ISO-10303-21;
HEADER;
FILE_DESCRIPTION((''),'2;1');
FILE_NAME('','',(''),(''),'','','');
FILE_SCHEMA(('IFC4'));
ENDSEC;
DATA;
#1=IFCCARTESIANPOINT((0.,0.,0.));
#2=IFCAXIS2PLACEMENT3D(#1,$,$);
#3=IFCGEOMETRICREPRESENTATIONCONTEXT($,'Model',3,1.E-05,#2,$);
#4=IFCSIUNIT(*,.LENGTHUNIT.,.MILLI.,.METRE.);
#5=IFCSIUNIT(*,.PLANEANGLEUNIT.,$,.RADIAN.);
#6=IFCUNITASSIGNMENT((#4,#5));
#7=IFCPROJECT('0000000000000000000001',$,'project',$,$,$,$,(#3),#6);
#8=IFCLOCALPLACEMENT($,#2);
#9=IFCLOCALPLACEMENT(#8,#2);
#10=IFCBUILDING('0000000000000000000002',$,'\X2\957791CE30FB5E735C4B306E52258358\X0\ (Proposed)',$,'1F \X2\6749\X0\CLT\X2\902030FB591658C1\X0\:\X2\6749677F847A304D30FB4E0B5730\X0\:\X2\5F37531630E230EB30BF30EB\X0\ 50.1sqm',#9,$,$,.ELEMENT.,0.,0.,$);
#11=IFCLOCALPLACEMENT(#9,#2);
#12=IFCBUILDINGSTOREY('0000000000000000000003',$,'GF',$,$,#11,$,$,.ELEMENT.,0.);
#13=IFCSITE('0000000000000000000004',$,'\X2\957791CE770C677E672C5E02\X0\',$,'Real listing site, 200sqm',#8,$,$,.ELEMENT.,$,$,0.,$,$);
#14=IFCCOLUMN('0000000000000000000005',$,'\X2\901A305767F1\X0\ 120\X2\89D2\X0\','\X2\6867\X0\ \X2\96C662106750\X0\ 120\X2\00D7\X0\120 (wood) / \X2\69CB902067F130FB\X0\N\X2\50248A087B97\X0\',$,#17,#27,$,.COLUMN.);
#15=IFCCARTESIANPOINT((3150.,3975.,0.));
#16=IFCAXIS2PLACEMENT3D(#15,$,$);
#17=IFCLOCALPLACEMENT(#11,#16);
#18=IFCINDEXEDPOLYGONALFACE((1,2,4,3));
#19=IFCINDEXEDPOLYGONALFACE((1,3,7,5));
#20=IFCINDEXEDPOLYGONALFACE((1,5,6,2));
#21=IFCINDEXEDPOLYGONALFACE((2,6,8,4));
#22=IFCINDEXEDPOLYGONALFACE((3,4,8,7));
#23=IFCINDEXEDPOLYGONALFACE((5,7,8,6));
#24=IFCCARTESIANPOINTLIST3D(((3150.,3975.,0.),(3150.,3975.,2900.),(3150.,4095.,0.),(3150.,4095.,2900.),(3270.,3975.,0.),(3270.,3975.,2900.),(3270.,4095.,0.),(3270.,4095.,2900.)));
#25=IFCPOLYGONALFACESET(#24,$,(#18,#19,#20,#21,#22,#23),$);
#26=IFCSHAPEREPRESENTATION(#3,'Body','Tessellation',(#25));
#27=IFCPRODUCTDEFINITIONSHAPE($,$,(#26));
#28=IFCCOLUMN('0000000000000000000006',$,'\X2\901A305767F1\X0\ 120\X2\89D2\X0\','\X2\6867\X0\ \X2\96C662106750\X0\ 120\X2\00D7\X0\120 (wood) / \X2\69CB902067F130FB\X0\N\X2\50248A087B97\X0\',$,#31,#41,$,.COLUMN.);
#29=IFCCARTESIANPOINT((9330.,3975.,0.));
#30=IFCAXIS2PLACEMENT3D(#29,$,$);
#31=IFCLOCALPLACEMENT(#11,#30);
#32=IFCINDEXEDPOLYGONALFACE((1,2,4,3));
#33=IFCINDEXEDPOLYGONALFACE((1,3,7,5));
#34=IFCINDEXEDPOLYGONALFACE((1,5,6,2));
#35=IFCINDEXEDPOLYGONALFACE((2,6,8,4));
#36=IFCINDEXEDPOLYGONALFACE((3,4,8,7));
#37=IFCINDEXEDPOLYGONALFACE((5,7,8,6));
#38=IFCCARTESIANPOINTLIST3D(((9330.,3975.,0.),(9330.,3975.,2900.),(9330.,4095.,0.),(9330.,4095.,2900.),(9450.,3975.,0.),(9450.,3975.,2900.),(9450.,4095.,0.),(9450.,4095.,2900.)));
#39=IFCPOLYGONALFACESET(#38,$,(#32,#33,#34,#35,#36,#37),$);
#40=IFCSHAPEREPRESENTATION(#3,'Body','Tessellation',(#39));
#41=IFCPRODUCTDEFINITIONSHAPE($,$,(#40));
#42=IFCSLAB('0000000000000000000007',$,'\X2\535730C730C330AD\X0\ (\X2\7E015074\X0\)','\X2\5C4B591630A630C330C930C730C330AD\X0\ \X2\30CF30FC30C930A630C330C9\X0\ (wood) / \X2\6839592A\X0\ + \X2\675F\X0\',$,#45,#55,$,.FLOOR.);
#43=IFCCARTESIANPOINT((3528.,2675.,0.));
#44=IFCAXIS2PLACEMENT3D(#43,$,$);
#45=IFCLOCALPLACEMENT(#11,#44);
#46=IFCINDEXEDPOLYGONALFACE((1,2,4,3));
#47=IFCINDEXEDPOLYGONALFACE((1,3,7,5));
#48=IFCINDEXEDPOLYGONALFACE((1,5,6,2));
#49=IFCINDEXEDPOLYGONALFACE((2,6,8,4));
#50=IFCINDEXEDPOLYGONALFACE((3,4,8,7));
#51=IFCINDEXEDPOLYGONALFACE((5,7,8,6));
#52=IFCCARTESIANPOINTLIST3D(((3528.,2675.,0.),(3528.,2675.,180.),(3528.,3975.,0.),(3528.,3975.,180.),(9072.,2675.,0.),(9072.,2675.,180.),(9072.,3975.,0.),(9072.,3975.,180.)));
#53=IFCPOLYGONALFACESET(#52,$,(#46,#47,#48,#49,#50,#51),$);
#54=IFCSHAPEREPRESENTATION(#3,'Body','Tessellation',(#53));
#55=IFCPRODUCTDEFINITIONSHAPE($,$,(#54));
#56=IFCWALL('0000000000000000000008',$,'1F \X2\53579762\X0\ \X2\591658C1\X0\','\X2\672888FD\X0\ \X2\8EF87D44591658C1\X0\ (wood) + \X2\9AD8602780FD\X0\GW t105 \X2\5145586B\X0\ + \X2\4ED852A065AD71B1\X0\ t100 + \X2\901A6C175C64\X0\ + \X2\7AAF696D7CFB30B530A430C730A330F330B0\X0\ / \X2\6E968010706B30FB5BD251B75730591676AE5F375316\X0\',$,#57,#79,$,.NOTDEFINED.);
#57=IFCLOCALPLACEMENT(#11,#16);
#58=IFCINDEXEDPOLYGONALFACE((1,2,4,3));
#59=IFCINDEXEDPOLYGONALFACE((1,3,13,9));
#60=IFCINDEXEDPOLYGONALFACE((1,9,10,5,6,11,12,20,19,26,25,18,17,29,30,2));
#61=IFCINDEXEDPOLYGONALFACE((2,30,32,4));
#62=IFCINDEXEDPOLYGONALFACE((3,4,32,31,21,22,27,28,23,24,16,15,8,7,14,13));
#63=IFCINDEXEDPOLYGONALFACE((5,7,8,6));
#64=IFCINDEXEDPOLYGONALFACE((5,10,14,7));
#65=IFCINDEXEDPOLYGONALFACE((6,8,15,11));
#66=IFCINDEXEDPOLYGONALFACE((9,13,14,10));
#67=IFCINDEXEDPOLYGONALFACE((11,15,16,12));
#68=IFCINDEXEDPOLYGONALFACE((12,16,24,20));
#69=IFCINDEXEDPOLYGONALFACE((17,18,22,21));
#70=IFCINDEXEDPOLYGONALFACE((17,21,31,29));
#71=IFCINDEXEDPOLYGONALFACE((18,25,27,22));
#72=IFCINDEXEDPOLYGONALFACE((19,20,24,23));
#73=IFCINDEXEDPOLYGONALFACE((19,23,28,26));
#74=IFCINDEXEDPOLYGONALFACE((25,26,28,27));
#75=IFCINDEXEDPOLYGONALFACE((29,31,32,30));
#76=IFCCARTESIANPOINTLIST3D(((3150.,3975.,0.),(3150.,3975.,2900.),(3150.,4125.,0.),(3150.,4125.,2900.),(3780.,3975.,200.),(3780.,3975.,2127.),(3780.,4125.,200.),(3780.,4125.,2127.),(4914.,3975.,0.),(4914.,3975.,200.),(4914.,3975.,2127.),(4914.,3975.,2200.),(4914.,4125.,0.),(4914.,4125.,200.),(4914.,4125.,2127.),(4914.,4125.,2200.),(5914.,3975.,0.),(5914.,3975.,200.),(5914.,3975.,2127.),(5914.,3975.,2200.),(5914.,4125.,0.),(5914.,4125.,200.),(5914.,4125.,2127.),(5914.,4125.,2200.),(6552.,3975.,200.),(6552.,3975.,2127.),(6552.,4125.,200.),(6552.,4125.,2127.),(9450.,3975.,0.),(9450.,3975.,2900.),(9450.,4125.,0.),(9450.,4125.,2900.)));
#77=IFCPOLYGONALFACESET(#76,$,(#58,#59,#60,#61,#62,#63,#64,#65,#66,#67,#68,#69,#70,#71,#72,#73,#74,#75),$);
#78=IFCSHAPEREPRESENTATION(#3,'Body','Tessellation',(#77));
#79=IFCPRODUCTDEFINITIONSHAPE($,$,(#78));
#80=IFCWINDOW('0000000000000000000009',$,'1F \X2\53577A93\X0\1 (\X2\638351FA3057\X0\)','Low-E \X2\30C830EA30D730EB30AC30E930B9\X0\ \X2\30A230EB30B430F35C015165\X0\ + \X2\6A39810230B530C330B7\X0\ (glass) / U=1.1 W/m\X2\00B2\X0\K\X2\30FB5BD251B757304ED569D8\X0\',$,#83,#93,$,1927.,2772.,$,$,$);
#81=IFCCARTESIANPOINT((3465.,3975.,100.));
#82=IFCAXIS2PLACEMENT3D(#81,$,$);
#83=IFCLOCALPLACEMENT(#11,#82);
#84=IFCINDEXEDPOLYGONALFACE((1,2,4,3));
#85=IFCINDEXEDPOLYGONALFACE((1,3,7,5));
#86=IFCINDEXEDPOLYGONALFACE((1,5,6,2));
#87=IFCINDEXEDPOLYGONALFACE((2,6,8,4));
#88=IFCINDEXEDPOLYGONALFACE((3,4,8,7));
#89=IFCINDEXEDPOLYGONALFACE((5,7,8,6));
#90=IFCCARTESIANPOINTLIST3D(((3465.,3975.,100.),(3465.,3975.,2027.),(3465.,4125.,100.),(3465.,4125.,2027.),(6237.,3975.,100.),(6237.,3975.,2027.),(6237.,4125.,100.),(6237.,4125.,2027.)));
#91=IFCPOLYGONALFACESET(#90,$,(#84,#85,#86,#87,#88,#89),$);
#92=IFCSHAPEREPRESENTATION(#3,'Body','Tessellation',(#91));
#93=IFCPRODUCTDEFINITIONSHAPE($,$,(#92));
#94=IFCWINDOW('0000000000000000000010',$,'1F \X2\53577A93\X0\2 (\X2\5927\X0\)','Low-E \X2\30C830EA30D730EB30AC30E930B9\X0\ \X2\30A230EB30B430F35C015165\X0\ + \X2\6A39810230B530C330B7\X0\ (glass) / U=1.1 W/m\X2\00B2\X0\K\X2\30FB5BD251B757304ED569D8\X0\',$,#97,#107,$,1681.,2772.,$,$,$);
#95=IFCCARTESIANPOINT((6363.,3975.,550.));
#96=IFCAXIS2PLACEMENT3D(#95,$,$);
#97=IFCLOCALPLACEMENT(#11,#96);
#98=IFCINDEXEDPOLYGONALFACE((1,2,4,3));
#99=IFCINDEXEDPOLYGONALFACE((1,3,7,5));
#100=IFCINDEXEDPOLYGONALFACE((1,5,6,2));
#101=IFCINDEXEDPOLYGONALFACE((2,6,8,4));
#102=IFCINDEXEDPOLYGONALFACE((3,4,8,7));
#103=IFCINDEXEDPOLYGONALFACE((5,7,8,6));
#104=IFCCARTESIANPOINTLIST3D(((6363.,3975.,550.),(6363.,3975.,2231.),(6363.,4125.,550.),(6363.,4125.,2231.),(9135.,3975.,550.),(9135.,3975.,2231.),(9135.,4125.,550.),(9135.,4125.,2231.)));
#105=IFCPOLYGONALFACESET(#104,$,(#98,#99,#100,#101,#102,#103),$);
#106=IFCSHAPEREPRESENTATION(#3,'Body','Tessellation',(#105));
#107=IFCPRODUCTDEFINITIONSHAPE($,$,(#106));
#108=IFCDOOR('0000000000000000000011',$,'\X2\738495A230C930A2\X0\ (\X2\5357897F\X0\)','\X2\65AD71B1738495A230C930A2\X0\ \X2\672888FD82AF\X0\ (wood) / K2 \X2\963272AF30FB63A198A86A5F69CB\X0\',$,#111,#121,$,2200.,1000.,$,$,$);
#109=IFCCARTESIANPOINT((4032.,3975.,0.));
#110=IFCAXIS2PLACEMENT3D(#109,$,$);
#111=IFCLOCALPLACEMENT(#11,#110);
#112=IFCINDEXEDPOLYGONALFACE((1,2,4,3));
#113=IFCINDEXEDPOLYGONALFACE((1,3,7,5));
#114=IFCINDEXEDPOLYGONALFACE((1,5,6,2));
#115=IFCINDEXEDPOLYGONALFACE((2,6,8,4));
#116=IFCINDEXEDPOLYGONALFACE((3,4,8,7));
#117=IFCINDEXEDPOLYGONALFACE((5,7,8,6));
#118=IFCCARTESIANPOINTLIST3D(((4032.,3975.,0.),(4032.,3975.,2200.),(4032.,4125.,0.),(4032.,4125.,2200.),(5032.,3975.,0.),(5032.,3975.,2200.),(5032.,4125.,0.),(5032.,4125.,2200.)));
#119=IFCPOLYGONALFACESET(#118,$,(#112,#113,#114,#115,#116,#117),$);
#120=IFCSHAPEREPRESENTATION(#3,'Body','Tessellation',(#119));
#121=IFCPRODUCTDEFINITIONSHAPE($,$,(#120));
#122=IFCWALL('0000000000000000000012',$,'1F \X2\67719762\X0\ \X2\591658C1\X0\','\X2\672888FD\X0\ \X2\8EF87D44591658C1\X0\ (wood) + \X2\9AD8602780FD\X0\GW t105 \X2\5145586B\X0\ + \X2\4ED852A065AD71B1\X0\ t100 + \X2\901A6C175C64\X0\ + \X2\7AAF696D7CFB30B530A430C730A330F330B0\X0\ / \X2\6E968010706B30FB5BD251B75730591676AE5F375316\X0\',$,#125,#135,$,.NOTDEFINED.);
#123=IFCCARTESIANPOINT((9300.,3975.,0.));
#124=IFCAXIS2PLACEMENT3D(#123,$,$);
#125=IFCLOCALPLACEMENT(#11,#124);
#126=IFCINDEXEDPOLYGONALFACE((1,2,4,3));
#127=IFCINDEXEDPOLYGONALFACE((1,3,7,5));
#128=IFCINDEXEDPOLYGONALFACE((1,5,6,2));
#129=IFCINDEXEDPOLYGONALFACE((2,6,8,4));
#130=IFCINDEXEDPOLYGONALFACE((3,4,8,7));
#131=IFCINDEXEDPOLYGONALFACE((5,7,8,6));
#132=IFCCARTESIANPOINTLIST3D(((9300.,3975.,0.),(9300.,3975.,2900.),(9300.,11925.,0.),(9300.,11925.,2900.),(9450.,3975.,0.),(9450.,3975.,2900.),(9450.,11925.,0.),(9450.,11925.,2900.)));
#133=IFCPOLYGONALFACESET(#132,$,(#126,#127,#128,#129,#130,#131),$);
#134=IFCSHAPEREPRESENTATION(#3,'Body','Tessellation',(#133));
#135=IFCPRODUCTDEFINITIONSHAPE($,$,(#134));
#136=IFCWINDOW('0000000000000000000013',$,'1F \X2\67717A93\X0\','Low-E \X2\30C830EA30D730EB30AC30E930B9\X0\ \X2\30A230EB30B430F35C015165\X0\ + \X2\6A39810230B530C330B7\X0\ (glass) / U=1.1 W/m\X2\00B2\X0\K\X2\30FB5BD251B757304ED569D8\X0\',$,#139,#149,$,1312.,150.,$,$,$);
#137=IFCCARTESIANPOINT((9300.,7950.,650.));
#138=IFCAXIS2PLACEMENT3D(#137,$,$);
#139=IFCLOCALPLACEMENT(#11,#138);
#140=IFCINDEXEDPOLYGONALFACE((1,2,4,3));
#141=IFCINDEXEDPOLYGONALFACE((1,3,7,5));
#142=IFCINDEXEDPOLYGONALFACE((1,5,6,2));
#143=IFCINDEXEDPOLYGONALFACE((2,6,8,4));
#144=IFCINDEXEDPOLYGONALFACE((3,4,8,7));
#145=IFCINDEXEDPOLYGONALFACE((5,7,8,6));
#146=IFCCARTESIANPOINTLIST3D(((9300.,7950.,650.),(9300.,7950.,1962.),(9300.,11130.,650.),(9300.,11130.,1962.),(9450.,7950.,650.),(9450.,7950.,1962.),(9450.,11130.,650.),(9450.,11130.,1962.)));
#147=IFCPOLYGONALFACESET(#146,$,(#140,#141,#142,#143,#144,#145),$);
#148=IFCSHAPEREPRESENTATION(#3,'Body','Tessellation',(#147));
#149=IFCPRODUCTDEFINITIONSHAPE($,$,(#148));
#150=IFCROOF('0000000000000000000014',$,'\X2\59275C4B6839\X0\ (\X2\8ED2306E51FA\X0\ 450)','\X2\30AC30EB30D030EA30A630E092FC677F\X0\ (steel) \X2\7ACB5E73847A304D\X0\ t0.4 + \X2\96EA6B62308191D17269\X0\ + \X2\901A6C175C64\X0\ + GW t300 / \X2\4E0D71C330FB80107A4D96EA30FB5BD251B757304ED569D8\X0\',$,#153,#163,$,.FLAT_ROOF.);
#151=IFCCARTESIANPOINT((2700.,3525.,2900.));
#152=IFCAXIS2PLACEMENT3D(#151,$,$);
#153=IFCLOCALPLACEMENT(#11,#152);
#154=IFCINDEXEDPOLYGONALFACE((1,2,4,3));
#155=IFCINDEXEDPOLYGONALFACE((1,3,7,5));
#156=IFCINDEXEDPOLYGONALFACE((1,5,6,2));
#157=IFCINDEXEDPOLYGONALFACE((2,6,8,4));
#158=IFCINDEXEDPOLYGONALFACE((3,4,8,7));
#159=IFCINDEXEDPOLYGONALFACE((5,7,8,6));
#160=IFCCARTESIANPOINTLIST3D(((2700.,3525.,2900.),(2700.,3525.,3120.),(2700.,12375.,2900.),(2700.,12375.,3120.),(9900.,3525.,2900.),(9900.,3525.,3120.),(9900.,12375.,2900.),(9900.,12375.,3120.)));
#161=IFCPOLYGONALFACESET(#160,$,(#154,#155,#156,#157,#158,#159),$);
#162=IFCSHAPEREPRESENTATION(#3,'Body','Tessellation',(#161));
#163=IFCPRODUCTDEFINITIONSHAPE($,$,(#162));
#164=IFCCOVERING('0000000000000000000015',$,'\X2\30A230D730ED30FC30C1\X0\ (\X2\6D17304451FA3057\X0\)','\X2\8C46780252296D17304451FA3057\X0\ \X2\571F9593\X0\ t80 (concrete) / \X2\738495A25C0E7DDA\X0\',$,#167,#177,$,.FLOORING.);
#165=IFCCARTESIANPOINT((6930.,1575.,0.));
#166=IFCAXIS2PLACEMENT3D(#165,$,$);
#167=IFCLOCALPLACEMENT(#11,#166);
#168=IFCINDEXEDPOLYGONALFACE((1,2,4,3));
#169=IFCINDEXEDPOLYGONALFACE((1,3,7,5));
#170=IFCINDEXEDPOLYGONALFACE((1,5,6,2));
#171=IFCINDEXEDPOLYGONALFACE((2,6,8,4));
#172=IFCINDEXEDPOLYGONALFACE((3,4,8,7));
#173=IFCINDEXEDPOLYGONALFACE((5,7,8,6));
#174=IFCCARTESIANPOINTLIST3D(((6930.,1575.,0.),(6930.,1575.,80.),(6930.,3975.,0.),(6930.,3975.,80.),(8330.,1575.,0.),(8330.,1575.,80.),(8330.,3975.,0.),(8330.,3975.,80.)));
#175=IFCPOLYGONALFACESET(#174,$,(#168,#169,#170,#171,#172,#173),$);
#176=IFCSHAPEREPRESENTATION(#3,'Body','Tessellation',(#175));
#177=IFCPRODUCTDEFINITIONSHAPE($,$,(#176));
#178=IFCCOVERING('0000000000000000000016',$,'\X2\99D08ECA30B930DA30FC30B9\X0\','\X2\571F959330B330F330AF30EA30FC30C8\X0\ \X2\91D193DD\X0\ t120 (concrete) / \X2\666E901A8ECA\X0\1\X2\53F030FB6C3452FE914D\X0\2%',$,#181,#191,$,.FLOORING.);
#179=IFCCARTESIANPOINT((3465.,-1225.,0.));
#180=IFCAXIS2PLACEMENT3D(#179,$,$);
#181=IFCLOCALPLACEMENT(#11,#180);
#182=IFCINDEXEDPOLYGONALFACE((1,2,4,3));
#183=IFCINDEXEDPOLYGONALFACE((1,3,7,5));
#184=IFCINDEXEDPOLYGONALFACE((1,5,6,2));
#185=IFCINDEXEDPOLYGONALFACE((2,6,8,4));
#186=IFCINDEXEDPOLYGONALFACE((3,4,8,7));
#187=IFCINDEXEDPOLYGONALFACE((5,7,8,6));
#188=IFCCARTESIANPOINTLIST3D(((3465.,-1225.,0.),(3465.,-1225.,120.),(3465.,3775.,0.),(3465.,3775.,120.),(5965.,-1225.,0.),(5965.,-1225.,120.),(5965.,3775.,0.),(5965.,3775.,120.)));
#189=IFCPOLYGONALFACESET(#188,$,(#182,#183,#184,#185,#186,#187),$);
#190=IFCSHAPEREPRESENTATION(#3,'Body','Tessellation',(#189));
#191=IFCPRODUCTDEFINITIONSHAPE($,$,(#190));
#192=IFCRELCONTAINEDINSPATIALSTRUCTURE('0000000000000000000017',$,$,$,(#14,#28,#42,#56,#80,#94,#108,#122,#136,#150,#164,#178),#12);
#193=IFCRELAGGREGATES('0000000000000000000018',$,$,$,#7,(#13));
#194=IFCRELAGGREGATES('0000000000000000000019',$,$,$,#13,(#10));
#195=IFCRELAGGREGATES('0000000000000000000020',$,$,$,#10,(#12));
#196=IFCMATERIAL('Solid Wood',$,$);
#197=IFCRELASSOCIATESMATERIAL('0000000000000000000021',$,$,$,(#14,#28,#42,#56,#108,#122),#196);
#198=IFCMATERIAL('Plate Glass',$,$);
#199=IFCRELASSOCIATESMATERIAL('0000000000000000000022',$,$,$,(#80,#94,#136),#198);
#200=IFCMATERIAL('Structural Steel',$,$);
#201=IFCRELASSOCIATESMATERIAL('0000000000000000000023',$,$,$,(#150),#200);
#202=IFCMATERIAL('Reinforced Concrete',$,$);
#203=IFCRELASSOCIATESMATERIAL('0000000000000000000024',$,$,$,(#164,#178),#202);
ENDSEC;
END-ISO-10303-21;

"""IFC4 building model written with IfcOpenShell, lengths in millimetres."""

from ifc_helpers import new_model, si_unit, frame, frame_2d, origin, place, context, project, spatial, rectangle, extrude, material, element, fill, save


model = new_model("IFC4")

# Units and contexts
model_context = context("Model", 3, precision=1e-05, world=origin())
ifc_project = project(units=[si_unit("LENGTHUNIT", "METRE", prefix="MILLI"), si_unit("PLANEANGLEUNIT", "RADIAN")], contexts=[model_context])

# Site, building, storey
site_placement = place(None, origin())
site = spatial("IfcSite", under=ifc_project, at=site_placement, Name="長野県松本市", ObjectType="Real listing site, 200sqm", CompositionType="ELEMENT", RefElevation=0.0)
building_placement = place(site_placement, origin())
building = spatial("IfcBuilding", under=site, at=building_placement, Name="長野・平屋の別荘 (Proposed)", ObjectType="1F 杉CLT造・外壁:杉板葺き・下地:強化モルタル 50.1sqm", CompositionType="ELEMENT", ElevationOfRefHeight=0.0, ElevationOfTerrain=0.0)
storey_placement = place(building_placement, origin())
storey = spatial("IfcBuildingStorey", under=building, at=storey_placement, Name="GF", CompositionType="ELEMENT", Elevation=0.0)

# Columns
ifc_material_1 = material(Name="Solid Wood")
column_1_placement = place(storey_placement, frame((3150.0, 3975.0, 0.0)))
element("IfcColumn", 1, at=column_1_placement, inside=storey, material=ifc_material_1, Name="通し柱 120角", Description="桧 集成材 120×120 (wood) / 構造柱・N値計算", PredefinedType="COLUMN", context=model_context, shape_type="SweptSolid", body=[
    extrude(rectangle(XDim=120.0, YDim=120.0, at=frame_2d((60.0, 60.0))), frame((3150.0, 3975.0, 0.0)), (0.0, 0.0, 1.0), 2900.0),
])
column_2_placement = place(storey_placement, frame((9330.0, 3975.0, 0.0)))
element("IfcColumn", 2, at=column_2_placement, inside=storey, material=ifc_material_1, Name="通し柱 120角", Description="桧 集成材 120×120 (wood) / 構造柱・N値計算", PredefinedType="COLUMN", context=model_context, shape_type="SweptSolid", body=[
    extrude(rectangle(XDim=120.0, YDim=120.0, at=frame_2d((60.0, 60.0))), frame((9330.0, 3975.0, 0.0)), (0.0, 0.0, 1.0), 2900.0),
])

# Slab
ifc_material_2 = material(Name="Reinforced Concrete")
slab_1_placement = place(storey_placement, frame((3528.0, 2675.0, 0.0)))
element("IfcSlab", 3, at=slab_1_placement, inside=storey, material=ifc_material_1, Name="南デッキ (縁側)", Description="屋外ウッドデッキ ハードウッド (wood) / 根太 + 束", PredefinedType="FLOOR", context=model_context, shape_type="SweptSolid", body=[
    extrude(rectangle(XDim=5544.0, YDim=1300.0, at=frame_2d((2772.0, 650.0))), frame((3528.0, 2675.0, 0.0)), (0.0, 0.0, 1.0), 180.0),
])

# Wall, openings, windows, door
wall_1_placement = place(storey_placement, frame((3150.0, 3975.0, 0.0)))
wall_1 = element("IfcWall", 4, at=wall_1_placement, inside=storey, material=ifc_material_1, Name="1F 南面 外壁", Description="木製 軸組外壁 (wood) + 高性能GW t105 充填 + 付加断熱 t100 + 通気層 + 窯業系サイディング / 準耐火・寒冷地外皮強化", PredefinedType="NOTDEFINED", context=model_context, shape_type="SweptSolid", body=[
    extrude(rectangle(XDim=6300.0, YDim=150.0, at=frame_2d((3150.0, 75.0))), frame((3150.0, 3975.0, 0.0)), (0.0, 0.0, 1.0), 2900.0),
])
opening_1_placement = place(storey_placement, frame((3465.0, 3975.0, 100.0)))
opening_1 = element("IfcOpeningElement", 5, at=opening_1_placement, cuts=wall_1, PredefinedType="NOTDEFINED", context=model_context, shape_type="SweptSolid", body=[
    extrude(rectangle(XDim=2772.0, YDim=150.0, at=frame_2d((1386.0, 75.0))), frame((3465.0, 3975.0, 100.0)), (0.0, 0.0, 1.0), 1927.0),
])
opening_2_placement = place(storey_placement, frame((6363.0, 3975.0, 550.0)))
opening_2 = element("IfcOpeningElement", 6, at=opening_2_placement, cuts=wall_1, PredefinedType="NOTDEFINED", context=model_context, shape_type="SweptSolid", body=[
    extrude(rectangle(XDim=2772.0, YDim=150.0, at=frame_2d((1386.0, 75.0))), frame((6363.0, 3975.0, 550.0)), (0.0, 0.0, 1.0), 1681.0),
])
opening_3_placement = place(storey_placement, frame((4032.0, 3975.0, 0.0)))
opening_3 = element("IfcOpeningElement", 7, at=opening_3_placement, cuts=wall_1, PredefinedType="NOTDEFINED", context=model_context, shape_type="SweptSolid", body=[
    extrude(rectangle(XDim=1000.0, YDim=150.0, at=frame_2d((500.0, 75.0))), frame((4032.0, 3975.0, 0.0)), (0.0, 0.0, 1.0), 2200.0),
])
ifc_material_3 = material(Name="Plate Glass")
window_1_placement = place(storey_placement, frame((3465.0, 3975.0, 100.0)))
window_1 = element("IfcWindow", 8, at=window_1_placement, inside=storey, material=ifc_material_3, Name="1F 南窓1 (掃出し)", Description="Low-E トリプルガラス アルゴン封入 + 樹脂サッシ (glass) / U=1.1 W/m²K・寒冷地仕様", OverallHeight=1927.0, OverallWidth=2772.0, context=model_context, shape_type="SweptSolid", body=[
    extrude(rectangle(XDim=2772.0, YDim=150.0, at=frame_2d((1386.0, 75.0))), frame((3465.0, 3975.0, 100.0)), (0.0, 0.0, 1.0), 1927.0),
])
fill(opening_1, window_1)
window_2_placement = place(storey_placement, frame((6363.0, 3975.0, 550.0)))
window_2 = element("IfcWindow", 9, at=window_2_placement, inside=storey, material=ifc_material_3, Name="1F 南窓2 (大)", Description="Low-E トリプルガラス アルゴン封入 + 樹脂サッシ (glass) / U=1.1 W/m²K・寒冷地仕様", OverallHeight=1681.0, OverallWidth=2772.0, context=model_context, shape_type="SweptSolid", body=[
    extrude(rectangle(XDim=2772.0, YDim=150.0, at=frame_2d((1386.0, 75.0))), frame((6363.0, 3975.0, 550.0)), (0.0, 0.0, 1.0), 1681.0),
])
fill(opening_2, window_2)
door_placement = place(storey_placement, frame((4032.0, 3975.0, 0.0)))
door = element("IfcDoor", 10, at=door_placement, inside=storey, material=ifc_material_1, Name="玄関ドア (南西)", Description="断熱玄関ドア 木製芯 (wood) / K2 防犯・採風機構", OverallHeight=2200.0, OverallWidth=1000.0, context=model_context, shape_type="SweptSolid", body=[
    extrude(rectangle(XDim=1000.0, YDim=150.0, at=frame_2d((500.0, 75.0))), frame((4032.0, 3975.0, 0.0)), (0.0, 0.0, 1.0), 2200.0),
])
fill(opening_3, door)

# Wall, opening, window
wall_2_placement = place(storey_placement, frame((9300.0, 3975.0, 0.0)))
wall_2 = element("IfcWall", 11, at=wall_2_placement, inside=storey, material=ifc_material_1, Name="1F 東面 外壁", Description="木製 軸組外壁 (wood) + 高性能GW t105 充填 + 付加断熱 t100 + 通気層 + 窯業系サイディング / 準耐火・寒冷地外皮強化", PredefinedType="NOTDEFINED", context=model_context, shape_type="SweptSolid", body=[
    extrude(rectangle(XDim=150.0, YDim=7950.0, at=frame_2d((75.0, 3975.0))), frame((9300.0, 3975.0, 0.0)), (0.0, 0.0, 1.0), 2900.0),
])
opening_4_placement = place(storey_placement, frame((9300.0, 7950.0, 650.0)))
opening_4 = element("IfcOpeningElement", 12, at=opening_4_placement, cuts=wall_2, PredefinedType="NOTDEFINED", context=model_context, shape_type="SweptSolid", body=[
    extrude(rectangle(XDim=150.0, YDim=3180.0, at=frame_2d((75.0, 1590.0))), frame((9300.0, 7950.0, 650.0)), (0.0, 0.0, 1.0), 1312.0),
])
window_3_placement = place(storey_placement, frame((9300.0, 7950.0, 650.0)))
window_3 = element("IfcWindow", 13, at=window_3_placement, inside=storey, material=ifc_material_3, Name="1F 東窓", Description="Low-E トリプルガラス アルゴン封入 + 樹脂サッシ (glass) / U=1.1 W/m²K・寒冷地仕様", OverallHeight=1312.0, OverallWidth=150.0, context=model_context, shape_type="SweptSolid", body=[
    extrude(rectangle(XDim=150.0, YDim=3180.0, at=frame_2d((75.0, 1590.0))), frame((9300.0, 7950.0, 650.0)), (0.0, 0.0, 1.0), 1312.0),
])
fill(opening_4, window_3)

# Roof
ifc_material_4 = material(Name="Structural Steel")
roof_placement = place(storey_placement, frame((2700.0, 3525.0, 2900.0)))
element("IfcRoof", 14, at=roof_placement, inside=storey, material=ifc_material_4, Name="大屋根 (軒の出 450)", Description="ガルバリウム鋼板 (steel) 立平葺き t0.4 + 雪止め金物 + 通気層 + GW t300 / 不燃・耐積雪・寒冷地仕様", PredefinedType="FLAT_ROOF", context=model_context, shape_type="SweptSolid", body=[
    extrude(rectangle(XDim=7200.0, YDim=8850.0, at=frame_2d((3600.0, 4425.0))), frame((2700.0, 3525.0, 2900.0)), (0.0, 0.0, 1.0), 220.0),
])

# Coverings
covering_1_placement = place(storey_placement, frame((6930.0, 1575.0, 0.0)))
element("IfcCovering", 15, at=covering_1_placement, inside=storey, material=ifc_material_2, Name="アプローチ (洗い出し)", Description="豆砂利洗い出し 土間 t80 (concrete) / 玄関導線", PredefinedType="FLOORING", context=model_context, shape_type="SweptSolid", body=[
    extrude(rectangle(XDim=1400.0, YDim=2400.0, at=frame_2d((700.0, 1200.0))), frame((6930.0, 1575.0, 0.0)), (0.0, 0.0, 1.0), 80.0),
])
covering_2_placement = place(storey_placement, frame((3465.0, -1225.0, 0.0)))
element("IfcCovering", 16, at=covering_2_placement, inside=storey, material=ifc_material_2, Name="駐車スペース", Description="土間コンクリート 金鏝 t120 (concrete) / 普通車1台・水勾配2%", PredefinedType="FLOORING", context=model_context, shape_type="SweptSolid", body=[
    extrude(rectangle(XDim=2500.0, YDim=5000.0, at=frame_2d((1250.0, 2500.0))), frame((3465.0, -1225.0, 0.0)), (0.0, 0.0, 1.0), 120.0),
])

save(model, "model.ifc")
